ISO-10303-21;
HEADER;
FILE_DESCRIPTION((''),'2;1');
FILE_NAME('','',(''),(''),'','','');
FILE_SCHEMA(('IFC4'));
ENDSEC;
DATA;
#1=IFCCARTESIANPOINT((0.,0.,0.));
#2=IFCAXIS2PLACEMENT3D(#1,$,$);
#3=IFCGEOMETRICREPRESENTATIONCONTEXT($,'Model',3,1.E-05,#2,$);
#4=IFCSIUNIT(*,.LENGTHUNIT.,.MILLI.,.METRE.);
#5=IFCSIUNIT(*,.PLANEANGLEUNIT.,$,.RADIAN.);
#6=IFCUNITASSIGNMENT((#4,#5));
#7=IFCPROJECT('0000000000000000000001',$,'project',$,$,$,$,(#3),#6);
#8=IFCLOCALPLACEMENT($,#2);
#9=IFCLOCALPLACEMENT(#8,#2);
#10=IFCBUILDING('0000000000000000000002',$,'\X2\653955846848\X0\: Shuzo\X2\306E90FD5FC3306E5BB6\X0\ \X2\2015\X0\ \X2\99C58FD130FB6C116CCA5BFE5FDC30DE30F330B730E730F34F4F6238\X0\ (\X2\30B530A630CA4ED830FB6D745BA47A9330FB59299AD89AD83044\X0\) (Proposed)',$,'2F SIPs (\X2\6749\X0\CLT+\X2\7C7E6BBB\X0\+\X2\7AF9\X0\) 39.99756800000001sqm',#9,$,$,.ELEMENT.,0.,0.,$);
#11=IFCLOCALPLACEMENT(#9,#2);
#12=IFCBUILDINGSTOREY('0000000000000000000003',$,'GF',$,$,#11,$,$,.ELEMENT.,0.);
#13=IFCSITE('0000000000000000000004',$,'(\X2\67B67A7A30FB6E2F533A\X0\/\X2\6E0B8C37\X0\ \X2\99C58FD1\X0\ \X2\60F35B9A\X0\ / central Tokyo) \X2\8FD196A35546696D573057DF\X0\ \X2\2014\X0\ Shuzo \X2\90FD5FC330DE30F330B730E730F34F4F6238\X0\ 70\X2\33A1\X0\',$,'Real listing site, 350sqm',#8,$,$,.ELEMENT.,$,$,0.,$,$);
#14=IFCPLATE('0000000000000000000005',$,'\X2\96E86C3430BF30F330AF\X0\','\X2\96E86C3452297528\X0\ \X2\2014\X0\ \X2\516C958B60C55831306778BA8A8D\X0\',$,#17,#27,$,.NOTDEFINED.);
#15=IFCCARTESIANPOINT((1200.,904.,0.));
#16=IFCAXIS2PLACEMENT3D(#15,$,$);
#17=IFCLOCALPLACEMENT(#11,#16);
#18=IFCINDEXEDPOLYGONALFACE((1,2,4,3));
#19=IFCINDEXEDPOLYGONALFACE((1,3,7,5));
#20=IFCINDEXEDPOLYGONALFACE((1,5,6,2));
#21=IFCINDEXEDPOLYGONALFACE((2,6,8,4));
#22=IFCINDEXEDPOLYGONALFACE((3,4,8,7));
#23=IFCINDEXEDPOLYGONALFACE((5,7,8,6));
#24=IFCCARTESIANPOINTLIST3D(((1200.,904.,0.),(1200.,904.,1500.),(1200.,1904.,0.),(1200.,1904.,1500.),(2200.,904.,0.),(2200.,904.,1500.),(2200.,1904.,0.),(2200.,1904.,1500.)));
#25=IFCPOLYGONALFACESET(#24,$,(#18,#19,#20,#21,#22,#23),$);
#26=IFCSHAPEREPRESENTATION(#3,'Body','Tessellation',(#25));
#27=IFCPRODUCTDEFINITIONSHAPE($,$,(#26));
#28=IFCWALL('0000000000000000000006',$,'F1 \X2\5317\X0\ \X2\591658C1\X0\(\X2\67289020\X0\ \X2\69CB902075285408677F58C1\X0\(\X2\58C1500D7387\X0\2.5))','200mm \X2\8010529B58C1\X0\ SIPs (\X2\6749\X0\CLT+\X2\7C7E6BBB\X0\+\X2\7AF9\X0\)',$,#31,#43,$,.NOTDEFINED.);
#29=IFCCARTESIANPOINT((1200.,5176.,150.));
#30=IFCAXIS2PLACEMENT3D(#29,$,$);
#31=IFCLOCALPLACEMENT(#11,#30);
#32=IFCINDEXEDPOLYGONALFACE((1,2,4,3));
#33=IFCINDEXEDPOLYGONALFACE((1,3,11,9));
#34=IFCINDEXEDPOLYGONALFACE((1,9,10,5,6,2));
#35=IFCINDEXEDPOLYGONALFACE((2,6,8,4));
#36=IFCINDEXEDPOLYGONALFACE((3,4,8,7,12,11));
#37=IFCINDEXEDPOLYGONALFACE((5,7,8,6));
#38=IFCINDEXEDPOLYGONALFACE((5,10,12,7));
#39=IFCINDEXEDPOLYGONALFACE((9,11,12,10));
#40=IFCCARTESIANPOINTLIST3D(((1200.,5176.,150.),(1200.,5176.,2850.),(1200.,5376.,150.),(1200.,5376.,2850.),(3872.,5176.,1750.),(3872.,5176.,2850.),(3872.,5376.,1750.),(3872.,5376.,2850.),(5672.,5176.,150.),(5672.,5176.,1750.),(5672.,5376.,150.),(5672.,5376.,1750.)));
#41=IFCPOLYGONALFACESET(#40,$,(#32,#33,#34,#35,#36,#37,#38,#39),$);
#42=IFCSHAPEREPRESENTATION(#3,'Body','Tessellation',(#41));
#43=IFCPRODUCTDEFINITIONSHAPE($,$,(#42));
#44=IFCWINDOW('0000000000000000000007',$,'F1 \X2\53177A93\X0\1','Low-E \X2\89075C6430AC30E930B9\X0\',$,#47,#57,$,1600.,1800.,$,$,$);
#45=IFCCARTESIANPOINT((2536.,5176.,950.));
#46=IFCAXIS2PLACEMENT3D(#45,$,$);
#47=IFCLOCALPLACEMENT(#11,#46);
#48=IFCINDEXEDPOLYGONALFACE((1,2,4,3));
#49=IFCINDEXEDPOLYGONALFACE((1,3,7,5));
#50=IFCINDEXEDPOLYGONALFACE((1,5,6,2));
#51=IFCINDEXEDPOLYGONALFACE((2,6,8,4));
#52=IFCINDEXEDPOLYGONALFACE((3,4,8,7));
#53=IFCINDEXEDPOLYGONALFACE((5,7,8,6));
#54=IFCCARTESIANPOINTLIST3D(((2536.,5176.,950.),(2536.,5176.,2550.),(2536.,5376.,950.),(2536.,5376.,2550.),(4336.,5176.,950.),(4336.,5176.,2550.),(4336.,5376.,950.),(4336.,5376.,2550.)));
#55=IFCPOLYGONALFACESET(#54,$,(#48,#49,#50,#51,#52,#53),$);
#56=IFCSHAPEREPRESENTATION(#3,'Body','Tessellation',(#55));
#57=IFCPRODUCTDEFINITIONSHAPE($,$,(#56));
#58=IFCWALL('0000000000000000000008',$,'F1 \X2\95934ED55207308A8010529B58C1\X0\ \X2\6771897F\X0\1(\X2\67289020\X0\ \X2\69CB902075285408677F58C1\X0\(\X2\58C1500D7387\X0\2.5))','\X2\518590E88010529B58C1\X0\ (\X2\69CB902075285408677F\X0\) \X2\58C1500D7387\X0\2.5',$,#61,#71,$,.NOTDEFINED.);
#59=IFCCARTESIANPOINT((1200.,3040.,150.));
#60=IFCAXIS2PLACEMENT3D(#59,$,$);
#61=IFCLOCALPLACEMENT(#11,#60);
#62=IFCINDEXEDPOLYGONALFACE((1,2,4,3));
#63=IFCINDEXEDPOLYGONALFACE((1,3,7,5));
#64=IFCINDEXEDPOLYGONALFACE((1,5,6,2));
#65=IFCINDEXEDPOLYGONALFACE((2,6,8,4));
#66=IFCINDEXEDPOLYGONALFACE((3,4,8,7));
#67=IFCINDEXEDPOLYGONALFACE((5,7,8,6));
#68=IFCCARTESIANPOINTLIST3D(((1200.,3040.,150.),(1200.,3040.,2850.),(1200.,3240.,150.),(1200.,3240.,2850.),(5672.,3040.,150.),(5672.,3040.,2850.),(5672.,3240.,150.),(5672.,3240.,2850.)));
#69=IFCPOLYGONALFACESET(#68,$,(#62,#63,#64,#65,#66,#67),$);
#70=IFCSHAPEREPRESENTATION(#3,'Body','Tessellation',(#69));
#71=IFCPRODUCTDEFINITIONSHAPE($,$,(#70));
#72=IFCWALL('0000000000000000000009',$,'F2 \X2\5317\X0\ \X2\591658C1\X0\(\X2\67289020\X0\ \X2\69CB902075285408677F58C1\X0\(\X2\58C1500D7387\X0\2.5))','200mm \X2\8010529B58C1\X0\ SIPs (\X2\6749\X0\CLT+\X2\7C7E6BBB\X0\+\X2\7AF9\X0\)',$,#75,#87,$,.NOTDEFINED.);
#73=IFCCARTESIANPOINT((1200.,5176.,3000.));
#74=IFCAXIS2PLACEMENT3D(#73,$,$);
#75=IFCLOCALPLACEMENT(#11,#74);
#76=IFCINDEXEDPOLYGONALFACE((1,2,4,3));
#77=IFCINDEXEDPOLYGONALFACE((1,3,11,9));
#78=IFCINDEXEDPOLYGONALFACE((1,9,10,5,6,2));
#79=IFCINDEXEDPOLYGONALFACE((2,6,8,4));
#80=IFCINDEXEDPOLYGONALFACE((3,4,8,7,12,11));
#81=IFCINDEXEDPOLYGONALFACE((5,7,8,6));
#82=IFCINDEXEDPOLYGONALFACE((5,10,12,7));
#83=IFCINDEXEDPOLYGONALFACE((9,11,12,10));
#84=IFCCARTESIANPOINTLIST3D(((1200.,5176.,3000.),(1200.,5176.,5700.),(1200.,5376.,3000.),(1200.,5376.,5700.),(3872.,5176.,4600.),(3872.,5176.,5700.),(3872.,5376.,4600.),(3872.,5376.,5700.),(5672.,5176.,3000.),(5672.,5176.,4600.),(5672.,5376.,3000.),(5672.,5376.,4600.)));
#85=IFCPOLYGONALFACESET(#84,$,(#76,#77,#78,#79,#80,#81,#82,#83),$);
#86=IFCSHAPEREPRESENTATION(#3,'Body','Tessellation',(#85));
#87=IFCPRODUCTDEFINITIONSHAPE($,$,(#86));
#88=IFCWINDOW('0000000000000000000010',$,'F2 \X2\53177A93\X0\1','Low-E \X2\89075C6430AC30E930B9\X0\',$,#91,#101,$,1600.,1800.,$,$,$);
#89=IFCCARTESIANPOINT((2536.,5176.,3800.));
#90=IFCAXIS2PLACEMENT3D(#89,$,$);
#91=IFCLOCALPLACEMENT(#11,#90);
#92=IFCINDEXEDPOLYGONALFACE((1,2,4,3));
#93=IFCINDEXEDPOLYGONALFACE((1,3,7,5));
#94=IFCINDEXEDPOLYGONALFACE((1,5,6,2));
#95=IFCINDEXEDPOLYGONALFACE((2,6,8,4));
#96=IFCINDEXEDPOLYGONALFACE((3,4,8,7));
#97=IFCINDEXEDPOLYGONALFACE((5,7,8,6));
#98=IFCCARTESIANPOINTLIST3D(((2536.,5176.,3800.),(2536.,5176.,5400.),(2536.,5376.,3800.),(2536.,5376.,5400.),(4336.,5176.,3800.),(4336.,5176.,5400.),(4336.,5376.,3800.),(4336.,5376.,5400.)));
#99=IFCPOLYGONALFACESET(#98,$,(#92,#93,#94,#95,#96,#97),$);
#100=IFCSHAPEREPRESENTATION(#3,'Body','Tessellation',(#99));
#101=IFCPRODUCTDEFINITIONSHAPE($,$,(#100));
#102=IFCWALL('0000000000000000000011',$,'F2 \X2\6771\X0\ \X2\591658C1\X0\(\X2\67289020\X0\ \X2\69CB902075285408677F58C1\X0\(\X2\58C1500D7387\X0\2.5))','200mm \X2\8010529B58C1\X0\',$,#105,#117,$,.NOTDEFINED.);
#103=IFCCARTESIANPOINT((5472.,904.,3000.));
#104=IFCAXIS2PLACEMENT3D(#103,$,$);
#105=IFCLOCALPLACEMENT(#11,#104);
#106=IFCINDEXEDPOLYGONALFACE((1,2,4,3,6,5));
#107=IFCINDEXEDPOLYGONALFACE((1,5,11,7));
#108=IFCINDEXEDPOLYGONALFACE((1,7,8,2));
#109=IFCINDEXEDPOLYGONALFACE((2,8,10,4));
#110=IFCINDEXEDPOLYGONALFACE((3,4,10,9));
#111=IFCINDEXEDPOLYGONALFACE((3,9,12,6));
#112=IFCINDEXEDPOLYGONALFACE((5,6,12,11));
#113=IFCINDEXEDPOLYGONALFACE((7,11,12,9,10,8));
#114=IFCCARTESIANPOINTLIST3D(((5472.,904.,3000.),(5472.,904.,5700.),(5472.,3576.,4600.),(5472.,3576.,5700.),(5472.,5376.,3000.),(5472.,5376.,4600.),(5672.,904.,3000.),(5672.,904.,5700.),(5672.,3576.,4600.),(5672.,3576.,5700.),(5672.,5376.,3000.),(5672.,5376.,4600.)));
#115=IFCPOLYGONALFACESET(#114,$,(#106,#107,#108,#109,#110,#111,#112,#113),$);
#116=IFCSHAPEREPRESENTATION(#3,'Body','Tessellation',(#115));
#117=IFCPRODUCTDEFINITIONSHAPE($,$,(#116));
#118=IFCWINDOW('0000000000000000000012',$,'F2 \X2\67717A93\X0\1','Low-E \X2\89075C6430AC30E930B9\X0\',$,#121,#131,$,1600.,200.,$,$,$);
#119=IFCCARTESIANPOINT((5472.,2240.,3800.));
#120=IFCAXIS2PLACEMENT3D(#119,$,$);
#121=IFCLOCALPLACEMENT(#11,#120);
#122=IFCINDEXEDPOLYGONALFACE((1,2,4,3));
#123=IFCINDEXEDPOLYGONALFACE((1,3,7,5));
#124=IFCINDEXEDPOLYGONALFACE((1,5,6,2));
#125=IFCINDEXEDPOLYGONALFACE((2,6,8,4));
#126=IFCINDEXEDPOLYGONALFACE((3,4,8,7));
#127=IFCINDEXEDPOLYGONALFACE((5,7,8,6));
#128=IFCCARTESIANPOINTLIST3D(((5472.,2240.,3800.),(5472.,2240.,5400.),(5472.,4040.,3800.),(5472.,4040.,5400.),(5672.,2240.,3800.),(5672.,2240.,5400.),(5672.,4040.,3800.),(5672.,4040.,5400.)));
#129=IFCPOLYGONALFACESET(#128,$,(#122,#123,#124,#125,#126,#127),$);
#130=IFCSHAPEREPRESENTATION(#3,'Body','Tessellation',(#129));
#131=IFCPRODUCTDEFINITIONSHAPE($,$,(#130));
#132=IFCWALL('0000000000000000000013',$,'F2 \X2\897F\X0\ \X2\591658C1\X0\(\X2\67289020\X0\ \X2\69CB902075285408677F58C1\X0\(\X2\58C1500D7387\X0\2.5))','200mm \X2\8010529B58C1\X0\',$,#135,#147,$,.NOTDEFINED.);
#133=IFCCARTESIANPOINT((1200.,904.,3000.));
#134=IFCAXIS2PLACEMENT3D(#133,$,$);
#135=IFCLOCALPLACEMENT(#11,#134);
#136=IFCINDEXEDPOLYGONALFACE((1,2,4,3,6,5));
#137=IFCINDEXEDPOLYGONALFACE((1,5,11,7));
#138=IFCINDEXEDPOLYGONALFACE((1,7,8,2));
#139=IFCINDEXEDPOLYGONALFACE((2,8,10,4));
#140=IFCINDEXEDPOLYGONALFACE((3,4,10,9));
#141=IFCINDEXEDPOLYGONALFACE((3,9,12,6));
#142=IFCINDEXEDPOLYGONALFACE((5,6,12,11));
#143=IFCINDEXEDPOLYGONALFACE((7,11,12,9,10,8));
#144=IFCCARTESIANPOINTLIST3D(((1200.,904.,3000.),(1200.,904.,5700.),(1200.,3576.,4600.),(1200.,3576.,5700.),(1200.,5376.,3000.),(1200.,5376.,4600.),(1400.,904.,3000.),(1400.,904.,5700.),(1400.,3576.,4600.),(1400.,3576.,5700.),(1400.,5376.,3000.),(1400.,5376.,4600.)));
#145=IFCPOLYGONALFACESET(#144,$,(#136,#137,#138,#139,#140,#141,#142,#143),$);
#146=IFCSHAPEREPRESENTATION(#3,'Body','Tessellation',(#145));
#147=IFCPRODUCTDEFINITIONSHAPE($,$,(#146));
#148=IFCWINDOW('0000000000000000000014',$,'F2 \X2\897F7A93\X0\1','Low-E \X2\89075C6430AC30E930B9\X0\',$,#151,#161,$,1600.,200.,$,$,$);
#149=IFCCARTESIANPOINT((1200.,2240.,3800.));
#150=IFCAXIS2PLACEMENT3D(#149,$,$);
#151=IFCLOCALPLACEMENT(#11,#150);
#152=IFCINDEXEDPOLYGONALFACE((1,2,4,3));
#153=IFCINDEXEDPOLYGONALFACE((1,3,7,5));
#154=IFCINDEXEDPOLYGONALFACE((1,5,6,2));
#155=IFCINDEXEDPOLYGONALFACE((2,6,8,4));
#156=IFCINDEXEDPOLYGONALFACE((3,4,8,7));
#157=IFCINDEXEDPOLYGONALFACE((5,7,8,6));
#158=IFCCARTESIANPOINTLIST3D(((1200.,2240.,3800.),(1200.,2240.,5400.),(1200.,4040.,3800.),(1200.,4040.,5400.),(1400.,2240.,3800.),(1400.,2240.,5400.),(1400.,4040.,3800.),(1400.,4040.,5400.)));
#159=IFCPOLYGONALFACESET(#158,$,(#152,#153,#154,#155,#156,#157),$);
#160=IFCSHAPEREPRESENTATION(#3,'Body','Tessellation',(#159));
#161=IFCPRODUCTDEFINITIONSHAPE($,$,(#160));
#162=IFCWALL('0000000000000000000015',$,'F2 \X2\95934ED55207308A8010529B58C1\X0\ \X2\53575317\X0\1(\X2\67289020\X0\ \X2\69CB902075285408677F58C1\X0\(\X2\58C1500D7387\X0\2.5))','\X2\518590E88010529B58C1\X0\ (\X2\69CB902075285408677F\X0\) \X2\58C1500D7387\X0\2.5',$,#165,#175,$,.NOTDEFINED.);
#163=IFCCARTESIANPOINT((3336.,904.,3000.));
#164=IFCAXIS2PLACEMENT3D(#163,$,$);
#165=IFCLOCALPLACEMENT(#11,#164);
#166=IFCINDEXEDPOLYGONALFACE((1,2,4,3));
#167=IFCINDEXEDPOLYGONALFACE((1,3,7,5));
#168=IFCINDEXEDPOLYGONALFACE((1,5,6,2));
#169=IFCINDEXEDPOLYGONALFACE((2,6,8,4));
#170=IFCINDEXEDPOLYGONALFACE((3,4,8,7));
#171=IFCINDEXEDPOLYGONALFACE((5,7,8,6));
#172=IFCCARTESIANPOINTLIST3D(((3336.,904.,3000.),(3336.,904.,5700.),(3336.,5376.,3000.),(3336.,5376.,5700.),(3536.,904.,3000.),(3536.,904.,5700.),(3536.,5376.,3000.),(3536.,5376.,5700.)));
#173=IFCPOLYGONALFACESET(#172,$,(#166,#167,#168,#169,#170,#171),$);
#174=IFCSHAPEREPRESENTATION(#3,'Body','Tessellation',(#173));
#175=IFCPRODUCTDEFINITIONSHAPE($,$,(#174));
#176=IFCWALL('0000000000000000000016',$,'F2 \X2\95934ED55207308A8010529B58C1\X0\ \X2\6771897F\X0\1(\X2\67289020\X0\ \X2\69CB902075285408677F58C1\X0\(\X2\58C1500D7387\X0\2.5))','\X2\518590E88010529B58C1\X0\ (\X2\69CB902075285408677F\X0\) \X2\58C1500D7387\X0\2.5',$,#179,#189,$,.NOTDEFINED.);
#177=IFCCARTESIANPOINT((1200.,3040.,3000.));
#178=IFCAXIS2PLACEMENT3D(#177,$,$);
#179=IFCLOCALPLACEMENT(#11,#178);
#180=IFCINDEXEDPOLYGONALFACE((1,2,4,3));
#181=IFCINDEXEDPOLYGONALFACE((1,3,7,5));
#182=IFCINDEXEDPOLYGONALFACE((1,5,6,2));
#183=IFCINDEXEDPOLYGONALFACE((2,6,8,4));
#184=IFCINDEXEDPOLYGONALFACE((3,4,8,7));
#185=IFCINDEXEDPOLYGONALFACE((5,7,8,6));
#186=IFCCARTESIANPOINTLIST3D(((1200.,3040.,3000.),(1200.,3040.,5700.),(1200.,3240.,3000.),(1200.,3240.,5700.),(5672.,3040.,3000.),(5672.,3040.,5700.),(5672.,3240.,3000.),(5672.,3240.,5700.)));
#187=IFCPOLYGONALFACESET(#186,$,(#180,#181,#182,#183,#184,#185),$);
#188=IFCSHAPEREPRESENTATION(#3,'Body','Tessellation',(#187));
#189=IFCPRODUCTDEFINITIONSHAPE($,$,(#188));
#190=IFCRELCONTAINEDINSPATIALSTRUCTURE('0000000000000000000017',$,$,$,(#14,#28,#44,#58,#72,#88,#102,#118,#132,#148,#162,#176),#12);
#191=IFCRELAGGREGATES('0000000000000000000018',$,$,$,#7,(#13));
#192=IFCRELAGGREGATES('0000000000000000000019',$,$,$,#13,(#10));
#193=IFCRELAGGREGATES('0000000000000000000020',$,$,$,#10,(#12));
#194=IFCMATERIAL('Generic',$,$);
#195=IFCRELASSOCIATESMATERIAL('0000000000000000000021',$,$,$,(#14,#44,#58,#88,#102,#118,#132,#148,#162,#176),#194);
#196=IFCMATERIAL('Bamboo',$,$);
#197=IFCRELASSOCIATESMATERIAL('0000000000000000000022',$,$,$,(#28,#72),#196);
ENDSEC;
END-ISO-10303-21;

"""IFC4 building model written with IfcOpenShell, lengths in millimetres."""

from ifc_helpers import new_model, si_unit, frame, frame_2d, origin, place, context, project, spatial, rectangle, extrude, material, element, fill, save


model = new_model("IFC4")

# Units and contexts
model_context = context("Model", 3, precision=1e-05, world=origin())
ifc_project = project(units=[si_unit("LENGTHUNIT", "METRE", prefix="MILLI"), si_unit("PLANEANGLEUNIT", "RADIAN")], contexts=[model_context])

# Site, building, storey
site_placement = place(None, origin())
site = spatial("IfcSite", under=ifc_project, at=site_placement, Name="(架空・港区/渋谷 駅近 想定 / central Tokyo) 近隣商業地域 — Shuzo 都心マンション住戸 70㎡", ObjectType="Real listing site, 350sqm", CompositionType="ELEMENT", RefElevation=0.0)
building_placement = place(site_placement, origin())
building = spatial("IfcBuilding", under=site, at=building_placement, Name="改善案: Shuzoの都心の家 ― 駅近・民泊対応マンション住戸 (サウナ付・浴室窓・天高高い) (Proposed)", ObjectType="2F SIPs (杉CLT+籾殻+竹) 39.99756800000001sqm", CompositionType="ELEMENT", ElevationOfRefHeight=0.0, ElevationOfTerrain=0.0)
storey_placement = place(building_placement, origin())
storey = spatial("IfcBuildingStorey", under=building, at=storey_placement, Name="GF", CompositionType="ELEMENT", Elevation=0.0)

# Plate
ifc_material_1 = material(Name="Generic")
plate_placement = place(storey_placement, frame((1200.0, 904.0, 0.0)))
element("IfcPlate", 1, at=plate_placement, inside=storey, material=ifc_material_1, Name="雨水タンク", Description="雨水利用 — 公開情報で確認", PredefinedType="NOTDEFINED", context=model_context, shape_type="SweptSolid", body=[
    extrude(rectangle(XDim=1000.0, YDim=1000.0, at=frame_2d((500.0, 500.0))), frame((1200.0, 904.0, 0.0)), (0.0, 0.0, 1.0), 1500.0),
])

# Wall, opening, window
ifc_material_2 = material(Name="Bamboo")
wall_1_placement = place(storey_placement, frame((1200.0, 5176.0, 150.0)))
wall_1 = element("IfcWall", 2, at=wall_1_placement, inside=storey, material=ifc_material_2, Name="F1 北 外壁(木造 構造用合板壁(壁倍率2.5))", Description="200mm 耐力壁 SIPs (杉CLT+籾殻+竹)", PredefinedType="NOTDEFINED", context=model_context, shape_type="SweptSolid", body=[
    extrude(rectangle(XDim=4472.0, YDim=200.0, at=frame_2d((2236.0, 100.0))), frame((1200.0, 5176.0, 150.0)), (0.0, 0.0, 1.0), 2700.0),
])
opening_1_placement = place(storey_placement, frame((2536.0, 5176.0, 950.0)))
opening_1 = element("IfcOpeningElement", 3, at=opening_1_placement, cuts=wall_1, PredefinedType="NOTDEFINED", context=model_context, shape_type="SweptSolid", body=[
    extrude(rectangle(XDim=1800.0, YDim=200.0, at=frame_2d((900.0, 100.0))), frame((2536.0, 5176.0, 950.0)), (0.0, 0.0, 1.0), 1600.0),
])
window_1_placement = place(storey_placement, frame((2536.0, 5176.0, 950.0)))
window_1 = element("IfcWindow", 4, at=window_1_placement, inside=storey, material=ifc_material_1, Name="F1 北窓1", Description="Low-E 複層ガラス", OverallHeight=1600.0, OverallWidth=1800.0, context=model_context, shape_type="SweptSolid", body=[
    extrude(rectangle(XDim=1800.0, YDim=200.0, at=frame_2d((900.0, 100.0))), frame((2536.0, 5176.0, 950.0)), (0.0, 0.0, 1.0), 1600.0),
])
fill(opening_1, window_1)

# Wall
wall_2_placement = place(storey_placement, frame((1200.0, 3040.0, 150.0)))
element("IfcWall", 5, at=wall_2_placement, inside=storey, material=ifc_material_1, Name="F1 間仕切り耐力壁 東西1(木造 構造用合板壁(壁倍率2.5))", Description="内部耐力壁 (構造用合板) 壁倍率2.5", PredefinedType="NOTDEFINED", context=model_context, shape_type="SweptSolid", body=[
    extrude(rectangle(XDim=4472.0, YDim=200.0, at=frame_2d((2236.0, 100.0))), frame((1200.0, 3040.0, 150.0)), (0.0, 0.0, 1.0), 2700.0),
])

# Walls, openings, windows
wall_3_placement = place(storey_placement, frame((1200.0, 5176.0, 3000.0)))
wall_3 = element("IfcWall", 6, at=wall_3_placement, inside=storey, material=ifc_material_2, Name="F2 北 外壁(木造 構造用合板壁(壁倍率2.5))", Description="200mm 耐力壁 SIPs (杉CLT+籾殻+竹)", PredefinedType="NOTDEFINED", context=model_context, shape_type="SweptSolid", body=[
    extrude(rectangle(XDim=4472.0, YDim=200.0, at=frame_2d((2236.0, 100.0))), frame((1200.0, 5176.0, 3000.0)), (0.0, 0.0, 1.0), 2700.0),
])
opening_2_placement = place(storey_placement, frame((2536.0, 5176.0, 3800.0)))
opening_2 = element("IfcOpeningElement", 7, at=opening_2_placement, cuts=wall_3, PredefinedType="NOTDEFINED", context=model_context, shape_type="SweptSolid", body=[
    extrude(rectangle(XDim=1800.0, YDim=200.0, at=frame_2d((900.0, 100.0))), frame((2536.0, 5176.0, 3800.0)), (0.0, 0.0, 1.0), 1600.0),
])
window_2_placement = place(storey_placement, frame((2536.0, 5176.0, 3800.0)))
window_2 = element("IfcWindow", 8, at=window_2_placement, inside=storey, material=ifc_material_1, Name="F2 北窓1", Description="Low-E 複層ガラス", OverallHeight=1600.0, OverallWidth=1800.0, context=model_context, shape_type="SweptSolid", body=[
    extrude(rectangle(XDim=1800.0, YDim=200.0, at=frame_2d((900.0, 100.0))), frame((2536.0, 5176.0, 3800.0)), (0.0, 0.0, 1.0), 1600.0),
])
fill(opening_2, window_2)
wall_4_placement = place(storey_placement, frame((5472.0, 904.0, 3000.0)))
wall_4 = element("IfcWall", 9, at=wall_4_placement, inside=storey, material=ifc_material_1, Name="F2 東 外壁(木造 構造用合板壁(壁倍率2.5))", Description="200mm 耐力壁", PredefinedType="NOTDEFINED", context=model_context, shape_type="SweptSolid", body=[
    extrude(rectangle(XDim=200.0, YDim=4472.0, at=frame_2d((100.0, 2236.0))), frame((5472.0, 904.0, 3000.0)), (0.0, 0.0, 1.0), 2700.0),
])
opening_3_placement = place(storey_placement, frame((5472.0, 2240.0, 3800.0)))
opening_3 = element("IfcOpeningElement", 10, at=opening_3_placement, cuts=wall_4, PredefinedType="NOTDEFINED", context=model_context, shape_type="SweptSolid", body=[
    extrude(rectangle(XDim=200.0, YDim=1800.0, at=frame_2d((100.0, 900.0))), frame((5472.0, 2240.0, 3800.0)), (0.0, 0.0, 1.0), 1600.0),
])
window_3_placement = place(storey_placement, frame((5472.0, 2240.0, 3800.0)))
window_3 = element("IfcWindow", 11, at=window_3_placement, inside=storey, material=ifc_material_1, Name="F2 東窓1", Description="Low-E 複層ガラス", OverallHeight=1600.0, OverallWidth=200.0, context=model_context, shape_type="SweptSolid", body=[
    extrude(rectangle(XDim=200.0, YDim=1800.0, at=frame_2d((100.0, 900.0))), frame((5472.0, 2240.0, 3800.0)), (0.0, 0.0, 1.0), 1600.0),
])
fill(opening_3, window_3)
wall_5_placement = place(storey_placement, frame((1200.0, 904.0, 3000.0)))
wall_5 = element("IfcWall", 12, at=wall_5_placement, inside=storey, material=ifc_material_1, Name="F2 西 外壁(木造 構造用合板壁(壁倍率2.5))", Description="200mm 耐力壁", PredefinedType="NOTDEFINED", context=model_context, shape_type="SweptSolid", body=[
    extrude(rectangle(XDim=200.0, YDim=4472.0, at=frame_2d((100.0, 2236.0))), frame((1200.0, 904.0, 3000.0)), (0.0, 0.0, 1.0), 2700.0),
])
opening_4_placement = place(storey_placement, frame((1200.0, 2240.0, 3800.0)))
opening_4 = element("IfcOpeningElement", 13, at=opening_4_placement, cuts=wall_5, PredefinedType="NOTDEFINED", context=model_context, shape_type="SweptSolid", body=[
    extrude(rectangle(XDim=200.0, YDim=1800.0, at=frame_2d((100.0, 900.0))), frame((1200.0, 2240.0, 3800.0)), (0.0, 0.0, 1.0), 1600.0),
])
window_4_placement = place(storey_placement, frame((1200.0, 2240.0, 3800.0)))
window_4 = element("IfcWindow", 14, at=window_4_placement, inside=storey, material=ifc_material_1, Name="F2 西窓1", Description="Low-E 複層ガラス", OverallHeight=1600.0, OverallWidth=200.0, context=model_context, shape_type="SweptSolid", body=[
    extrude(rectangle(XDim=200.0, YDim=1800.0, at=frame_2d((100.0, 900.0))), frame((1200.0, 2240.0, 3800.0)), (0.0, 0.0, 1.0), 1600.0),
])
fill(opening_4, window_4)

# Walls
wall_6_placement = place(storey_placement, frame((3336.0, 904.0, 3000.0)))
element("IfcWall", 15, at=wall_6_placement, inside=storey, material=ifc_material_1, Name="F2 間仕切り耐力壁 南北1(木造 構造用合板壁(壁倍率2.5))", Description="内部耐力壁 (構造用合板) 壁倍率2.5", PredefinedType="NOTDEFINED", context=model_context, shape_type="SweptSolid", body=[
    extrude(rectangle(XDim=200.0, YDim=4472.0, at=frame_2d((100.0, 2236.0))), frame((3336.0, 904.0, 3000.0)), (0.0, 0.0, 1.0), 2700.0),
])
wall_7_placement = place(storey_placement, frame((1200.0, 3040.0, 3000.0)))
element("IfcWall", 16, at=wall_7_placement, inside=storey, material=ifc_material_1, Name="F2 間仕切り耐力壁 東西1(木造 構造用合板壁(壁倍率2.5))", Description="内部耐力壁 (構造用合板) 壁倍率2.5", PredefinedType="NOTDEFINED", context=model_context, shape_type="SweptSolid", body=[
    extrude(rectangle(XDim=4472.0, YDim=200.0, at=frame_2d((2236.0, 100.0))), frame((1200.0, 3040.0, 3000.0)), (0.0, 0.0, 1.0), 2700.0),
])

save(model, "model.ifc")
